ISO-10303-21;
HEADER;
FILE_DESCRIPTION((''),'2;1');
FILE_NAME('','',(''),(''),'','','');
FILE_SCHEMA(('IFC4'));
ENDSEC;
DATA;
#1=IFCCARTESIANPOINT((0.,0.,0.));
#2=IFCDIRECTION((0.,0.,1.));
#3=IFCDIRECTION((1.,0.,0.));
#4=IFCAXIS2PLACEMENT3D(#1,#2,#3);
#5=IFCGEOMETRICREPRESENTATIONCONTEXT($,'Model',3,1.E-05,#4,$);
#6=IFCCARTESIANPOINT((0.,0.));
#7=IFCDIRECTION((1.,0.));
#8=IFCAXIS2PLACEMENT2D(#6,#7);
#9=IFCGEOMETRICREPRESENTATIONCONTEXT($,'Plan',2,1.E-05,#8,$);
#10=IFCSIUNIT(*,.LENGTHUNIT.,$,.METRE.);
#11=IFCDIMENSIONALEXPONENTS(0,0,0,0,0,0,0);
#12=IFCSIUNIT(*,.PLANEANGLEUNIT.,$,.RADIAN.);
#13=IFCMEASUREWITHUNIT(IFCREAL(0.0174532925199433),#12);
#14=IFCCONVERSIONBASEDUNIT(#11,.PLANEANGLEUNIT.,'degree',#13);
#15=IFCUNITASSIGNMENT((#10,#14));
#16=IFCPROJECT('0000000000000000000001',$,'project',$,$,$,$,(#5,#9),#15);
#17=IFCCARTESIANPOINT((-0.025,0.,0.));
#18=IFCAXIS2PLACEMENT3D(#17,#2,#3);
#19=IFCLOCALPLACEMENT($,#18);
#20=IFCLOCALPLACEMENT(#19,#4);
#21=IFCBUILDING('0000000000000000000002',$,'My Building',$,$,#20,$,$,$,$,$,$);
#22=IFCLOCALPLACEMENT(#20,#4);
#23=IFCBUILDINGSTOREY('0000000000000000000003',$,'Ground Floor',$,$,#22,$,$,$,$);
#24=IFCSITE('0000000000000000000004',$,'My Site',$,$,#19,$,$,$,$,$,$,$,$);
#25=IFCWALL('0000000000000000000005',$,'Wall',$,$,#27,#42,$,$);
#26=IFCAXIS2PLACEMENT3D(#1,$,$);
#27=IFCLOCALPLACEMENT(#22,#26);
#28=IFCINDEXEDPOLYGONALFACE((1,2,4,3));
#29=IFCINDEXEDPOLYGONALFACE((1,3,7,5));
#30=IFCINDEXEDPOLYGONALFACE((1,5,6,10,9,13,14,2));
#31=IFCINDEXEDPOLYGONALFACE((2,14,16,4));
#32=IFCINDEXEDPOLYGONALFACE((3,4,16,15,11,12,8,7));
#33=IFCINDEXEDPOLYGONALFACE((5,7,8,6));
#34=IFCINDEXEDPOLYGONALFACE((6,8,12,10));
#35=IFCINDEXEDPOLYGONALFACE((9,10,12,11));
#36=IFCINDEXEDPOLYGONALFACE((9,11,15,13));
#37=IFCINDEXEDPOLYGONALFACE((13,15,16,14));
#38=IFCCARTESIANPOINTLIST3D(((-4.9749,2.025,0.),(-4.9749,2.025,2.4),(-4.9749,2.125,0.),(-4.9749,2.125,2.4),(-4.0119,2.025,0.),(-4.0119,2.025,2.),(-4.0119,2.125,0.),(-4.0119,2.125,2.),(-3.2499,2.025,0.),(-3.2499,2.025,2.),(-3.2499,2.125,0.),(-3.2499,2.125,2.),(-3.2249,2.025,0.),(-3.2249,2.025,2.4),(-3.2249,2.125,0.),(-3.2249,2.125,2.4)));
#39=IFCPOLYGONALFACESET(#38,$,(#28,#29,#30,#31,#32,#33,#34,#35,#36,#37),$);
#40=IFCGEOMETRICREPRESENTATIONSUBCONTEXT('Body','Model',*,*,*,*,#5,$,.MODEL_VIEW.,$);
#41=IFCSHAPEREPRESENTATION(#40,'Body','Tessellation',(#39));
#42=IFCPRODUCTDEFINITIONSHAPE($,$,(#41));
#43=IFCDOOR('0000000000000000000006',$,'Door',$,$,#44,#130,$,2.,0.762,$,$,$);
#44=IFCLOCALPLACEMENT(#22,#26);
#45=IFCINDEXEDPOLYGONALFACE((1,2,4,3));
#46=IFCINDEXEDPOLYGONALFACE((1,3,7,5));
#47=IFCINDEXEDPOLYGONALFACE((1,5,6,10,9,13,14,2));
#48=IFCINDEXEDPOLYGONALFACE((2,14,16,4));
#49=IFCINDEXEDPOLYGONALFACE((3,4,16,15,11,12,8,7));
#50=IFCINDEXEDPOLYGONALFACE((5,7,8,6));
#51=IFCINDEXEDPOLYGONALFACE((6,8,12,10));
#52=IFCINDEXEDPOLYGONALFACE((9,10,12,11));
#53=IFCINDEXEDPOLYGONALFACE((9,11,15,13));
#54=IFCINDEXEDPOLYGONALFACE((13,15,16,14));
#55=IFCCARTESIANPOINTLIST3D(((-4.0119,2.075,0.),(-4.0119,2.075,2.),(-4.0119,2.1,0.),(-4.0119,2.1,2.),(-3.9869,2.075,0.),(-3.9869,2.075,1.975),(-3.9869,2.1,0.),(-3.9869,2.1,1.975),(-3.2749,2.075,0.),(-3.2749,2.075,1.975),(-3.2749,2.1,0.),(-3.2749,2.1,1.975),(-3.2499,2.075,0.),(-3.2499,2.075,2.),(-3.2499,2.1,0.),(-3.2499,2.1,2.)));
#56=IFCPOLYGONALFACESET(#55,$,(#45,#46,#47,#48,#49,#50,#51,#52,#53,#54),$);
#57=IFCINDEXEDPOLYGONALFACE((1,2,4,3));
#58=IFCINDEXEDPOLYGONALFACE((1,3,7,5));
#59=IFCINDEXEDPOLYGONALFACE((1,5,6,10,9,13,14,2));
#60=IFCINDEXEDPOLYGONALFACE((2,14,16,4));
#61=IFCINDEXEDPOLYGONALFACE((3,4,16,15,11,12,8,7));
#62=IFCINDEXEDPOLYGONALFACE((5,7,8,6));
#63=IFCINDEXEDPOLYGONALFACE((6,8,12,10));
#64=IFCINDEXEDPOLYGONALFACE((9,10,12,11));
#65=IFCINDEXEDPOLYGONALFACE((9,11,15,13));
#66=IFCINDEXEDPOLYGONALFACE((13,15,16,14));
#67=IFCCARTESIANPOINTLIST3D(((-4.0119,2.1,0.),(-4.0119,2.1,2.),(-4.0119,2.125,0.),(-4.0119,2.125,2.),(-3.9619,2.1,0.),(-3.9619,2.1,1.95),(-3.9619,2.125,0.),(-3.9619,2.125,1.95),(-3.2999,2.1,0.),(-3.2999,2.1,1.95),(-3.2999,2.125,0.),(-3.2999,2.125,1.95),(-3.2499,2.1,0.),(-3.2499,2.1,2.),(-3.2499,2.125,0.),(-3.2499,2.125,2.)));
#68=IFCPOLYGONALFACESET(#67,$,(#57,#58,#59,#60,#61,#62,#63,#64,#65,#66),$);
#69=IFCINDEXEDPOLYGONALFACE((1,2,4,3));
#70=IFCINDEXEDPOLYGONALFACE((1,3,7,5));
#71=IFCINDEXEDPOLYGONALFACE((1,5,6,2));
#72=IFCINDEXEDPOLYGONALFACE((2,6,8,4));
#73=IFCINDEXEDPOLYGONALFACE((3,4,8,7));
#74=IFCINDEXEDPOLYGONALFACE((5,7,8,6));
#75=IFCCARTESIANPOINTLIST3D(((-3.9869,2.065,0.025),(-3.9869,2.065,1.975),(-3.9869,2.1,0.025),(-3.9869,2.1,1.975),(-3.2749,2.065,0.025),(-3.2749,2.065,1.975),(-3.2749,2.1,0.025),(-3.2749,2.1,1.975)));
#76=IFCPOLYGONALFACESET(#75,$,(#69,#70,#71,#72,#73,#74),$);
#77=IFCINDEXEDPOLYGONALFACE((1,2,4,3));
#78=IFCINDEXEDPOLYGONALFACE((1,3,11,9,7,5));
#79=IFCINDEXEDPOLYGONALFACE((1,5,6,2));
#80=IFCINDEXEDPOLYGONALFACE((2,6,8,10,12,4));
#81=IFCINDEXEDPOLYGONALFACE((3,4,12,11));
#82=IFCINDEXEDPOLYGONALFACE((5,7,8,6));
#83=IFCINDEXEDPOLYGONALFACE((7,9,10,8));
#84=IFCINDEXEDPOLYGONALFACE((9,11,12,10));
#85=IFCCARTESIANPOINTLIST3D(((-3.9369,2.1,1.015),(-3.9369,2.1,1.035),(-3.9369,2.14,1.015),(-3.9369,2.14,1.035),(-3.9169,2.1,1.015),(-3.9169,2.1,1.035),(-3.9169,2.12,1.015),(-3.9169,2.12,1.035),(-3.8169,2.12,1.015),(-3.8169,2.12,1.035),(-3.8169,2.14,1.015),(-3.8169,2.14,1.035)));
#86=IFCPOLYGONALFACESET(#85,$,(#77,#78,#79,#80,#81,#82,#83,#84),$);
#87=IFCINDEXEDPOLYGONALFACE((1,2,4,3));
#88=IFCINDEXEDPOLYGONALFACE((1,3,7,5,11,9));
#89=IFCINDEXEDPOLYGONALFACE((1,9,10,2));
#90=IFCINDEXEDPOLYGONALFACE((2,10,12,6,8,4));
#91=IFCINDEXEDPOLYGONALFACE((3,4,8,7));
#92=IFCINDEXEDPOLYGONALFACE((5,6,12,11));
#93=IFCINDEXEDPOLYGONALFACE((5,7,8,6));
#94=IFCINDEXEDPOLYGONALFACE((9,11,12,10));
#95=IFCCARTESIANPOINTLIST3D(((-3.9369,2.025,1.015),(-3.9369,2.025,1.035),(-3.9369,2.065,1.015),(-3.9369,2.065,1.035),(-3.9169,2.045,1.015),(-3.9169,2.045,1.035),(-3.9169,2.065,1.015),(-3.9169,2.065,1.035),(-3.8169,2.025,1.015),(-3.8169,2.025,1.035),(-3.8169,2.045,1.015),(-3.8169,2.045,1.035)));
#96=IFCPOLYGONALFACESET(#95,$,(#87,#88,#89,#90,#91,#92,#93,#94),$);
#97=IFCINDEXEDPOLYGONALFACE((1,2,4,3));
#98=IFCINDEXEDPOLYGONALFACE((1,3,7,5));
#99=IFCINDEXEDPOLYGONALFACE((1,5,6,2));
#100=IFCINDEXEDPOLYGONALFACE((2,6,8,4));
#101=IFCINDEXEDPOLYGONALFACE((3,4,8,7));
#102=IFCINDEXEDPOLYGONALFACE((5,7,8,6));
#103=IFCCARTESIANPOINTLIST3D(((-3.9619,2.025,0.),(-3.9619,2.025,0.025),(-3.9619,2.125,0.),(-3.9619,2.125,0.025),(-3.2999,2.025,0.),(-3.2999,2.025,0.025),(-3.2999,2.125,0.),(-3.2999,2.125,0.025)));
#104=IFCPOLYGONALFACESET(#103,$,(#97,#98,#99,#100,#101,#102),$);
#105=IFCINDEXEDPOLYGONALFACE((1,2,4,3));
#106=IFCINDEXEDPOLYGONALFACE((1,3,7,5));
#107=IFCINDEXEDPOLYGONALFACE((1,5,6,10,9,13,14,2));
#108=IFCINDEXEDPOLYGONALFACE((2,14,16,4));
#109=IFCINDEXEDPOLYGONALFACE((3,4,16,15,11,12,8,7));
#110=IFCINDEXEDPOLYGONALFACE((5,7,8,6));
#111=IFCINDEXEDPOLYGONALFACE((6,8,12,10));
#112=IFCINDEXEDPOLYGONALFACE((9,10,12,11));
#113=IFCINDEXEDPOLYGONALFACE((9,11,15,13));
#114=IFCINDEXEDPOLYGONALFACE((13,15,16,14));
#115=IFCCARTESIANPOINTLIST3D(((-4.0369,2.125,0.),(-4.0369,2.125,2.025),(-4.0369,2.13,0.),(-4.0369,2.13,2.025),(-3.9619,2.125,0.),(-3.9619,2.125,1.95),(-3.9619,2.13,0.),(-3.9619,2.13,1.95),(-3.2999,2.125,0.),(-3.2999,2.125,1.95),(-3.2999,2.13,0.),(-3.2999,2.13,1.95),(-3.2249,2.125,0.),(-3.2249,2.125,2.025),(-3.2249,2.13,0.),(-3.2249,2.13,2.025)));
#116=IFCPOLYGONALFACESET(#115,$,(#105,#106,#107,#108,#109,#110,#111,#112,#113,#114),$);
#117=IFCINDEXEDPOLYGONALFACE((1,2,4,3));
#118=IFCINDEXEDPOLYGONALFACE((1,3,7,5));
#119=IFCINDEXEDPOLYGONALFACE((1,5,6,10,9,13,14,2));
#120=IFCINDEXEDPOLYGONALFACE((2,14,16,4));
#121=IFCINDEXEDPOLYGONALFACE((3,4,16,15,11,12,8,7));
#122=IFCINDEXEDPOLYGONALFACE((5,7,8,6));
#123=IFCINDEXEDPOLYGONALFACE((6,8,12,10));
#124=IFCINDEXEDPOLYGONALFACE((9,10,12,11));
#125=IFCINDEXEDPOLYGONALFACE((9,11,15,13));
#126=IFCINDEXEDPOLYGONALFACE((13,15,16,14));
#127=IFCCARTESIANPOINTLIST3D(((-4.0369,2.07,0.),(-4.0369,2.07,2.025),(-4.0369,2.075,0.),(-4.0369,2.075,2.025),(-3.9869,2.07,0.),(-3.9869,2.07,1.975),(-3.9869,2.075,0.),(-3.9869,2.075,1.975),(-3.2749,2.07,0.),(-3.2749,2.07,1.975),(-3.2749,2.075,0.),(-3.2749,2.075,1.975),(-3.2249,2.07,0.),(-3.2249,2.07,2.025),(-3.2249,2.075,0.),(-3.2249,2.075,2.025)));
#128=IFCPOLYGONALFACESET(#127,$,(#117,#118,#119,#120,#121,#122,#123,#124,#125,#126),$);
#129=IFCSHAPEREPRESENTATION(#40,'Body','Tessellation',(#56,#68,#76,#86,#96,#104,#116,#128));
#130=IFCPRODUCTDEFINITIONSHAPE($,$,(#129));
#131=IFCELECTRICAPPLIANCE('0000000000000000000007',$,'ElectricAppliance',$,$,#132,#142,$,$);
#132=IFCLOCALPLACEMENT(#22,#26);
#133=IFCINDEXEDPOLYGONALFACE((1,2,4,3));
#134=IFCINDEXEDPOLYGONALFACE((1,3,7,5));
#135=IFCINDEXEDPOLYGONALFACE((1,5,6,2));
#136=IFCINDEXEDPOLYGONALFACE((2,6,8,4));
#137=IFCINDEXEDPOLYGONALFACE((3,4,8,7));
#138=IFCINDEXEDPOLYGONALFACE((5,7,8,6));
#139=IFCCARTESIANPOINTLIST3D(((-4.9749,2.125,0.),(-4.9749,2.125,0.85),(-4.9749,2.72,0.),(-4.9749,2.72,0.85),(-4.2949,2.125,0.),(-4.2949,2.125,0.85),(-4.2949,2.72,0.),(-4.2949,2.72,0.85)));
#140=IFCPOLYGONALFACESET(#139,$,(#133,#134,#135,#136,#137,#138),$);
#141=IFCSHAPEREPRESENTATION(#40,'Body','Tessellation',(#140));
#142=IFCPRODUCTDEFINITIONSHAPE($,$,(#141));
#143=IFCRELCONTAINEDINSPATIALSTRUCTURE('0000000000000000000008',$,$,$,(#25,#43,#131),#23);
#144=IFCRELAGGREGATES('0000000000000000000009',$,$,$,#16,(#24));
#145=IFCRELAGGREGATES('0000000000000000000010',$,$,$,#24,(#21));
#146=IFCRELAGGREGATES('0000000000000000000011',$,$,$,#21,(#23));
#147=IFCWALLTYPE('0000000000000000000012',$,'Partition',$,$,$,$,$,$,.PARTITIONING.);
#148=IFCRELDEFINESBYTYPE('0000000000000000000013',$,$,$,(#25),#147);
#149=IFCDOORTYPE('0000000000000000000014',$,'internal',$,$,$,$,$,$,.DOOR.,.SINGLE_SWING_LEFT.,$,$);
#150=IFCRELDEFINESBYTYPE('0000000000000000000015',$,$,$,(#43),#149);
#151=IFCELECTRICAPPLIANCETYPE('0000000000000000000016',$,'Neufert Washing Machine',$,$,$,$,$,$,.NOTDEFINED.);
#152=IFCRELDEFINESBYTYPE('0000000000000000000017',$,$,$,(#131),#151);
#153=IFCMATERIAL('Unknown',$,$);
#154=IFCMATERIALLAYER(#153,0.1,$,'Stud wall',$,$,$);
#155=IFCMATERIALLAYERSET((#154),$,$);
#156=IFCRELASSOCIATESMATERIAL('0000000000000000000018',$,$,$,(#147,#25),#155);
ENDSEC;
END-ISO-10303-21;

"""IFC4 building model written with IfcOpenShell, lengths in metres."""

from ifc_helpers import new_model, entity, si_unit, converted_unit, frame, origin_with_axes, origin_2d_with_axis, place, context, subcontext, project, spatial, line, indexed_curve, outline, extrude, shape, source, transform, mapped, material, layer, layer_set, layer_usage, type_object, type_shapes, element, fill, save


model = new_model("IFC4")

# Units and contexts
model_context = context("Model", 3, precision=1e-05, world=origin_with_axes())
plan_context = context("Plan", 2, precision=1e-05, world=origin_2d_with_axis())
body_context_1 = subcontext(model_context, "Body", "Model", "MODEL_VIEW")
body_context_2 = subcontext(plan_context, "Body", "Plan", "PLAN_VIEW")
ifc_project = project(units=[si_unit("LENGTHUNIT", "METRE"), converted_unit("PLANEANGLEUNIT", "degree", entity("IfcReal", 0.0174532925199433), si_unit("PLANEANGLEUNIT", "RADIAN"), dimensions=[0, 0, 0, 0, 0, 0, 0])], contexts=[model_context, plan_context])

# Site, building, storey
site_placement = place(None, frame((-0.025, 0.0, 0.0), z_axis=(0.0, 0.0, 1.0), x_axis=(1.0, 0.0, 0.0)))
site = spatial("IfcSite", under=ifc_project, at=site_placement, Name="My Site")
building_placement = place(site_placement, origin_with_axes())
building = spatial("IfcBuilding", under=site, at=building_placement, Name="My Building")
storey_placement = place(building_placement, frame((0.0, 0.0, 0.0), z_axis=(0.0, 0.0, 1.0), x_axis=(1.0, 0.0, 0.0)))
storey = spatial("IfcBuildingStorey", under=building, at=storey_placement, Name="Ground Floor")

# Shared definitions
ifc_material = material(Name="Unknown")
shared_shape_1 = source(origin_with_axes(), body_context_1, "Body", "SweptSolid", [
    extrude(outline(indexed_curve([(0.0, 0.0), (0.762, 0.0), (0.762, 2.0), (0.0, 2.0)], segments=[line(1, 2, 3, 4, 1)])), frame((0.0, -0.6, 0.0), z_axis=(0.0, -1.0, 0.0), x_axis=(1.0, 0.0, 0.0)), (0.0, 0.0, -1.0), 1.2),
])
door_type = type_object("IfcDoorType", Name="internal", OperationType="SINGLE_SWING_LEFT", PredefinedType="DOOR")
shared_shape_2 = source(origin_with_axes(), body_context_1, "Body", "SweptSolid", [
    extrude(outline(indexed_curve([(0.0, 0.0), (0.0, 2.0), (0.762, 2.0), (0.762, 0.0), (0.737, 0.0), (0.737, 1.975), (0.025, 1.975), (0.025, 0.0)], segments=[line(1, 2, 3, 4, 5, 6, 7, 8, 1)])), frame((0.0, 0.025, 0.0), z_axis=(0.0, -1.0, 0.0), x_axis=(1.0, 0.0, 0.0)), (0.0, 0.0, -1.0), 0.025),
    extrude(outline(indexed_curve([(0.0, 0.0), (0.0, 2.0), (0.762, 2.0), (0.762, 0.0), (0.712, 0.0), (0.712, 1.95), (0.05, 1.95), (0.05, 0.0)], segments=[line(1, 2, 3, 4, 5, 6, 7, 8, 1)])), frame((0.0, 0.0, 0.0), z_axis=(0.0, -1.0, 0.0), x_axis=(1.0, 0.0, 0.0)), (0.0, 0.0, -1.0), 0.025),
    extrude(outline(indexed_curve([(0.0, 0.0), (0.712, 0.0), (0.712, 0.035), (0.0, 0.035)], segments=[line(1, 2, 3, 4, 1)])), frame((0.025, 0.025, 0.025), z_axis=(0.0, 0.0, 1.0), x_axis=(1.0, 0.0, 0.0)), (0.0, 0.0, 1.0), 1.95),
    extrude(outline(indexed_curve([(0.0, 0.0), (0.0, -0.04), (-0.12, -0.04), (-0.12, -0.02), (-0.02, -0.02), (-0.02, 0.0)], segments=[line(1, 2, 3, 4, 5, 6, 1)])), frame((0.687, 0.025, 1.015), z_axis=(0.0, 0.0, 1.0), x_axis=(1.0, 0.0, 0.0)), (0.0, 0.0, 1.0), 0.02),
    extrude(outline(indexed_curve([(0.0, 0.0), (0.0, 0.04), (-0.12, 0.04), (-0.12, 0.02), (-0.02, 0.02), (-0.02, 0.0)], segments=[line(1, 2, 3, 4, 5, 6, 1)])), frame((0.687, 0.06, 1.015), z_axis=(0.0, 0.0, 1.0), x_axis=(1.0, 0.0, 0.0)), (0.0, 0.0, 1.0), 0.02),
    extrude(outline(indexed_curve([(0.0, 0.0), (0.662, 0.0), (0.662, 0.1), (0.0, 0.1)], segments=[line(1, 2, 3, 4, 1)])), frame((0.05, 0.0, 0.0), z_axis=(0.0, 0.0, 1.0), x_axis=(1.0, 0.0, 0.0)), (0.0, 0.0, 1.0), 0.025),
    extrude(outline(indexed_curve([(0.0, 0.0), (0.0, 2.025), (0.812, 2.025), (0.812, 0.0), (0.737, 0.0), (0.737, 1.95), (0.075, 1.95), (0.075, 0.0)], segments=[line(1, 2, 3, 4, 5, 6, 7, 8, 1)])), frame((-0.025, -0.005, 0.0), z_axis=(0.0, -1.0, 0.0), x_axis=(1.0, 0.0, 0.0)), (0.0, 0.0, -1.0), 0.005),
    extrude(outline(indexed_curve([(0.0, 0.0), (0.0, 2.025), (0.812, 2.025), (0.812, 0.0), (0.762, 0.0), (0.762, 1.975), (0.05, 1.975), (0.05, 0.0)], segments=[line(1, 2, 3, 4, 5, 6, 7, 8, 1)])), frame((-0.025, 0.05, 0.0), z_axis=(0.0, -1.0, 0.0), x_axis=(1.0, 0.0, 0.0)), (0.0, 0.0, -1.0), 0.005),
])
shared_shape_3 = source(origin_with_axes(), body_context_2, "Body", "Curve2D", [
    entity("IfcIndexedPolyCurve", entity("IfcCartesianPointList2D", [[0.0, 0.0], [0.0, 0.05], [0.025, 0.05], [0.025, 0.025], [0.05, 0.025], [0.05, 0.0]]), [entity("IfcLineIndex", [1, 2, 3, 4, 5, 6, 1])]),
    entity("IfcIndexedPolyCurve", entity("IfcCartesianPointList2D", [[0.762, 0.0], [0.762, 0.05], [0.737, 0.05], [0.737, 0.025], [0.712, 0.025], [0.712, 0.0]]), [entity("IfcLineIndex", [1, 2, 3, 4, 5, 6, 1])]),
    entity("IfcTrimmedCurve", entity("IfcEllipse", entity("IfcAxis2Placement2D", entity("IfcCartesianPoint", [0.06, 0.05]), entity("IfcDirection", [1.0, 0.0])), 0.677, 0.712), [entity("IfcCartesianPoint", [0.737, 0.05])], [entity("IfcCartesianPoint", [0.06, 0.762])], True, "CARTESIAN"),
    entity("IfcIndexedPolyCurve", entity("IfcCartesianPointList2D", [[0.025, 0.05], [0.06, 0.05], [0.06, 0.762], [0.025, 0.762]]), [entity("IfcLineIndex", [1, 2, 3, 4, 1])]),
])
type_shapes(door_type, [shared_shape_2, shared_shape_3])

# Wall, opening, door
ifc_layer_1 = layer(ifc_material, 0.1, Name="Stud wall")
ifc_layer_set_1 = layer_set([ifc_layer_1])
wall_type_1 = type_object("IfcWallType", Name="Partition", PredefinedType="PARTITIONING", material=ifc_layer_set_1)
ifc_layer_usage_1 = layer_usage(ifc_layer_set_1, "AXIS2", "POSITIVE", 0.0)
wall_1_placement = place(storey_placement, frame((-3.2249, 2.125, 0.0), z_axis=(0.0, 0.0, 1.0), x_axis=(-1.0, 0.0, 0.0)))
wall_1 = element("IfcWall", 1, at=wall_1_placement, inside=storey, type_object=wall_type_1, material=ifc_layer_usage_1, Name="Wall", context=body_context_1, shape_type="SweptSolid", body=[
    extrude(outline(indexed_curve([(0.0, 0.0), (0.0, 0.1), (1.75, 0.1), (1.75, 0.0), (0.0, 0.0)], self_intersect=False)), origin_with_axes(), (0.0, 0.0, 1.0), 2.4),
])
opening_1_placement = place(wall_1_placement, frame((0.025, 0.0, 0.0), z_axis=(0.0, 0.0, 1.0), x_axis=(1.0, 0.0, 0.0)))
opening_1 = element("IfcOpeningElement", 2, at=opening_1_placement, cuts=wall_1, PredefinedType="OPENING", context=body_context_1, shape_type="MappedRepresentation", body=[
    mapped(shared_shape_1, transform((0.0, 0.0, 0.0), x_axis=(1.0, 0.0, 0.0), y_axis=(0.0, 1.0, 0.0), z_axis=(0.0, 0.0, 1.0), scale=1.0)),
])
door_1_placement = place(opening_1_placement, frame((0.0, 0.0, 0.0), z_axis=(0.0, 0.0, 1.0), x_axis=(1.0, 0.0, 0.0)))
door_1 = element("IfcDoor", 3, at=door_1_placement, inside=storey, type_object=door_type, Name="Door", OverallHeight=2.0, OverallWidth=0.762, shapes=[
    shape(body_context_1, "Body", "MappedRepresentation", [mapped(shared_shape_2, transform((0.0, 0.0, 0.0), x_axis=(1.0, 0.0, 0.0), y_axis=(0.0, 1.0, 0.0), z_axis=(0.0, 0.0, 1.0), scale=1.0))]),
    shape(body_context_2, "Body", "MappedRepresentation", [mapped(shared_shape_3, transform((0.0, 0.0, 0.0), x_axis=(1.0, 0.0, 0.0), y_axis=(0.0, 1.0, 0.0), z_axis=(0.0, 0.0, 1.0), scale=1.0))]),
])
fill(opening_1, door_1)

# Electric appliance
electric_appliance_type_1 = type_object("IfcElectricApplianceType", Name="Neufert Washing Machine", PredefinedType="NOTDEFINED")
shared_shape_4 = source(origin_with_axes(), body_context_1, "Body", "SweptSolid", [
    extrude(outline(indexed_curve([(0.0, 0.0), (0.595, 0.0), (0.595, 0.68), (0.0, 0.68)], segments=[line(1, 2, 3, 4, 1)])), origin_with_axes(), (0.0, 0.0, 1.0), 0.85),
])
shared_shape_5 = source(origin_with_axes(), body_context_2, "Body", "Curve2D", [
    entity("IfcIndexedPolyCurve", entity("IfcCartesianPointList2D", [[0.0, 0.0], [0.595, 0.0], [0.595, 0.68], [0.0, 0.68]]), [entity("IfcLineIndex", [1, 2, 3, 4, 1])]),
    entity("IfcCircle", entity("IfcAxis2Placement2D", entity("IfcCartesianPoint", [0.2975, 0.34])), 0.1785),
    entity("IfcCircle", entity("IfcAxis2Placement2D", entity("IfcCartesianPoint", [0.2975, 0.34])), 0.0595),
])
type_shapes(electric_appliance_type_1, [shared_shape_4, shared_shape_5])
electric_appliance_1_placement = place(storey_placement, frame((-4.2949, 2.125, 0.0), z_axis=(0.0, 0.0, 1.0), x_axis=(0.0, 1.0, 0.0)))
element("IfcElectricAppliance", 4, at=electric_appliance_1_placement, inside=storey, type_object=electric_appliance_type_1, Name="ElectricAppliance", shapes=[
    shape(body_context_1, "Body", "MappedRepresentation", [mapped(shared_shape_4, transform((0.0, 0.0, 0.0), x_axis=(1.0, 0.0, 0.0), y_axis=(0.0, 1.0, 0.0), z_axis=(0.0, 0.0, 1.0), scale=1.0))]),
    shape(body_context_2, "Body", "MappedRepresentation", [mapped(shared_shape_5, transform((0.0, 0.0, 0.0), x_axis=(1.0, 0.0, 0.0), y_axis=(0.0, 1.0, 0.0), z_axis=(0.0, 0.0, 1.0), scale=1.0))]),
])

save(model, "model.ifc")
